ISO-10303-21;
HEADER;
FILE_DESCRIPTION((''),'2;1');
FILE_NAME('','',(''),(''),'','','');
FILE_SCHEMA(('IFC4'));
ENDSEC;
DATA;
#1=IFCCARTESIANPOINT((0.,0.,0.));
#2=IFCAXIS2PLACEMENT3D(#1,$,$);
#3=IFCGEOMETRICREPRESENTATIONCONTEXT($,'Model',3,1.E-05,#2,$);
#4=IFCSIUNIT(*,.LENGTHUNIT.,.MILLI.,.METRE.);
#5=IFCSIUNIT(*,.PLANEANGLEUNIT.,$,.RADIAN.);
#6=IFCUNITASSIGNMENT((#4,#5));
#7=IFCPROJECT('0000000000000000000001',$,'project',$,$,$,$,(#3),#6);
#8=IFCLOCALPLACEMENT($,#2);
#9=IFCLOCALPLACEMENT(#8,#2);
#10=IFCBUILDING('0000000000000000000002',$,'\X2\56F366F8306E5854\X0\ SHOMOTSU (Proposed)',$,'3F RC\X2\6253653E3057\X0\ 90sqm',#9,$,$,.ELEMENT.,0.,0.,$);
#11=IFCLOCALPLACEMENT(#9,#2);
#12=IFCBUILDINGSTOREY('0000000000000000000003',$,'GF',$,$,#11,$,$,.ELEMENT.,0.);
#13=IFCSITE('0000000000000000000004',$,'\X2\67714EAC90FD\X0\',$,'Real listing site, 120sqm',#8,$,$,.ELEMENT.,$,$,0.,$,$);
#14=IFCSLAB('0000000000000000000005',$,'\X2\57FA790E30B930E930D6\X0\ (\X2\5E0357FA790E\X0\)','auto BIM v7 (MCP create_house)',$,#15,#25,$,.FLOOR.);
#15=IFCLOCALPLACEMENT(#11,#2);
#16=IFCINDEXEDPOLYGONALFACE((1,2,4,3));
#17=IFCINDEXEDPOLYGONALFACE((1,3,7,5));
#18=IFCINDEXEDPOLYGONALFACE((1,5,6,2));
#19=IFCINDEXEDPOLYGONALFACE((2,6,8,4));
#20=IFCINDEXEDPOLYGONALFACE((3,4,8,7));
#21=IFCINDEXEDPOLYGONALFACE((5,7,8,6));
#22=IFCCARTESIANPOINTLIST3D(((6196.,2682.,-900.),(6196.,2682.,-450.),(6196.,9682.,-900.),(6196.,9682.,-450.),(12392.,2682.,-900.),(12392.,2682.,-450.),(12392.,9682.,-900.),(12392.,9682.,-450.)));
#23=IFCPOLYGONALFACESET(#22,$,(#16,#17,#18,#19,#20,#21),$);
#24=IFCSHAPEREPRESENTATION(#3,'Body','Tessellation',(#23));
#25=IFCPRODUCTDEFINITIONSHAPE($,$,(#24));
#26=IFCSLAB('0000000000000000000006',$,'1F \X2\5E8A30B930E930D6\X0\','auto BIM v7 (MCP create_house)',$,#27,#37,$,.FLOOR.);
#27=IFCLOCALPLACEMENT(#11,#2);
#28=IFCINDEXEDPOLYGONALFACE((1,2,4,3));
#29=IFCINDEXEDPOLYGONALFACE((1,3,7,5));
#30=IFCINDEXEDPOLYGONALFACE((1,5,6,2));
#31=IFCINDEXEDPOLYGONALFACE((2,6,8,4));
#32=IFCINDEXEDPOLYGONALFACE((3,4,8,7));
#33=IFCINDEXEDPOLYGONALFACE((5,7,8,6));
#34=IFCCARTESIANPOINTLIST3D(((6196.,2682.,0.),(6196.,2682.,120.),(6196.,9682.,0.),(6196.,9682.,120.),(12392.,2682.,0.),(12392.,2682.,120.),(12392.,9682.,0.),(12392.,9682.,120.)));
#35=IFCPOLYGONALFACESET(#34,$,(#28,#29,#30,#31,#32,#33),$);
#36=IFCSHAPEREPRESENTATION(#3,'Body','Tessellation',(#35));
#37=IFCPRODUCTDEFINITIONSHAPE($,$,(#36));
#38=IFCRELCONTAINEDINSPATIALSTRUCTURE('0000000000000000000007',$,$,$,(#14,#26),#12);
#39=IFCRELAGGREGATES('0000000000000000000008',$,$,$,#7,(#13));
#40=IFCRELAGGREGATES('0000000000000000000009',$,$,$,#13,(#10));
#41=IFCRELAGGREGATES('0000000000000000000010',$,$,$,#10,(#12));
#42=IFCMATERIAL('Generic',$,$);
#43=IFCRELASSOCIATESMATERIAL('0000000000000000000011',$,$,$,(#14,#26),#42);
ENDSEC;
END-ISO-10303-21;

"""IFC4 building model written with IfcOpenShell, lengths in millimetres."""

from ifc_helpers import new_model, si_unit, frame, frame_2d, origin, place, context, project, spatial, rectangle, extrude, material, element, save


model = new_model("IFC4")

# Units and contexts
model_context = context("Model", 3, precision=1e-05, world=origin())
ifc_project = project(units=[si_unit("LENGTHUNIT", "METRE", prefix="MILLI"), si_unit("PLANEANGLEUNIT", "RADIAN")], contexts=[model_context])

# Site, building, storey
site_placement = place(None, origin())
site = spatial("IfcSite", under=ifc_project, at=site_placement, Name="東京都", ObjectType="Real listing site, 120sqm", CompositionType="ELEMENT", RefElevation=0.0)
building_placement = place(site_placement, origin())
building = spatial("IfcBuilding", under=site, at=building_placement, Name="図書の塔 SHOMOTSU (Proposed)", ObjectType="3F RC打放し 90sqm", CompositionType="ELEMENT", ElevationOfRefHeight=0.0, ElevationOfTerrain=0.0)
storey_placement = place(building_placement, origin())
storey = spatial("IfcBuildingStorey", under=building, at=storey_placement, Name="GF", CompositionType="ELEMENT", Elevation=0.0)

# Slabs
ifc_material = material(Name="Generic")
slab_1_placement = place(storey_placement, frame((3098.0, 1341.0, -450.0)))
element("IfcSlab", 1, at=slab_1_placement, inside=storey, material=ifc_material, Name="基礎スラブ (布基礎)", Description="auto BIM v7 (MCP create_house)", PredefinedType="FLOOR", context=model_context, shape_type="SweptSolid", body=[
    extrude(rectangle(XDim=6196.0, YDim=7000.0, at=frame_2d((3098.0, 3500.0))), frame((3098.0, 1341.0, -450.0)), (0.0, 0.0, 1.0), 450.0),
])
slab_2_placement = place(storey_placement, frame((3098.0, 1341.0, 0.0)))
element("IfcSlab", 2, at=slab_2_placement, inside=storey, material=ifc_material, Name="1F 床スラブ", Description="auto BIM v7 (MCP create_house)", PredefinedType="FLOOR", context=model_context, shape_type="SweptSolid", body=[
    extrude(rectangle(XDim=6196.0, YDim=7000.0, at=frame_2d((3098.0, 3500.0))), frame((3098.0, 1341.0, 0.0)), (0.0, 0.0, 1.0), 120.0),
])

save(model, "model.ifc")
